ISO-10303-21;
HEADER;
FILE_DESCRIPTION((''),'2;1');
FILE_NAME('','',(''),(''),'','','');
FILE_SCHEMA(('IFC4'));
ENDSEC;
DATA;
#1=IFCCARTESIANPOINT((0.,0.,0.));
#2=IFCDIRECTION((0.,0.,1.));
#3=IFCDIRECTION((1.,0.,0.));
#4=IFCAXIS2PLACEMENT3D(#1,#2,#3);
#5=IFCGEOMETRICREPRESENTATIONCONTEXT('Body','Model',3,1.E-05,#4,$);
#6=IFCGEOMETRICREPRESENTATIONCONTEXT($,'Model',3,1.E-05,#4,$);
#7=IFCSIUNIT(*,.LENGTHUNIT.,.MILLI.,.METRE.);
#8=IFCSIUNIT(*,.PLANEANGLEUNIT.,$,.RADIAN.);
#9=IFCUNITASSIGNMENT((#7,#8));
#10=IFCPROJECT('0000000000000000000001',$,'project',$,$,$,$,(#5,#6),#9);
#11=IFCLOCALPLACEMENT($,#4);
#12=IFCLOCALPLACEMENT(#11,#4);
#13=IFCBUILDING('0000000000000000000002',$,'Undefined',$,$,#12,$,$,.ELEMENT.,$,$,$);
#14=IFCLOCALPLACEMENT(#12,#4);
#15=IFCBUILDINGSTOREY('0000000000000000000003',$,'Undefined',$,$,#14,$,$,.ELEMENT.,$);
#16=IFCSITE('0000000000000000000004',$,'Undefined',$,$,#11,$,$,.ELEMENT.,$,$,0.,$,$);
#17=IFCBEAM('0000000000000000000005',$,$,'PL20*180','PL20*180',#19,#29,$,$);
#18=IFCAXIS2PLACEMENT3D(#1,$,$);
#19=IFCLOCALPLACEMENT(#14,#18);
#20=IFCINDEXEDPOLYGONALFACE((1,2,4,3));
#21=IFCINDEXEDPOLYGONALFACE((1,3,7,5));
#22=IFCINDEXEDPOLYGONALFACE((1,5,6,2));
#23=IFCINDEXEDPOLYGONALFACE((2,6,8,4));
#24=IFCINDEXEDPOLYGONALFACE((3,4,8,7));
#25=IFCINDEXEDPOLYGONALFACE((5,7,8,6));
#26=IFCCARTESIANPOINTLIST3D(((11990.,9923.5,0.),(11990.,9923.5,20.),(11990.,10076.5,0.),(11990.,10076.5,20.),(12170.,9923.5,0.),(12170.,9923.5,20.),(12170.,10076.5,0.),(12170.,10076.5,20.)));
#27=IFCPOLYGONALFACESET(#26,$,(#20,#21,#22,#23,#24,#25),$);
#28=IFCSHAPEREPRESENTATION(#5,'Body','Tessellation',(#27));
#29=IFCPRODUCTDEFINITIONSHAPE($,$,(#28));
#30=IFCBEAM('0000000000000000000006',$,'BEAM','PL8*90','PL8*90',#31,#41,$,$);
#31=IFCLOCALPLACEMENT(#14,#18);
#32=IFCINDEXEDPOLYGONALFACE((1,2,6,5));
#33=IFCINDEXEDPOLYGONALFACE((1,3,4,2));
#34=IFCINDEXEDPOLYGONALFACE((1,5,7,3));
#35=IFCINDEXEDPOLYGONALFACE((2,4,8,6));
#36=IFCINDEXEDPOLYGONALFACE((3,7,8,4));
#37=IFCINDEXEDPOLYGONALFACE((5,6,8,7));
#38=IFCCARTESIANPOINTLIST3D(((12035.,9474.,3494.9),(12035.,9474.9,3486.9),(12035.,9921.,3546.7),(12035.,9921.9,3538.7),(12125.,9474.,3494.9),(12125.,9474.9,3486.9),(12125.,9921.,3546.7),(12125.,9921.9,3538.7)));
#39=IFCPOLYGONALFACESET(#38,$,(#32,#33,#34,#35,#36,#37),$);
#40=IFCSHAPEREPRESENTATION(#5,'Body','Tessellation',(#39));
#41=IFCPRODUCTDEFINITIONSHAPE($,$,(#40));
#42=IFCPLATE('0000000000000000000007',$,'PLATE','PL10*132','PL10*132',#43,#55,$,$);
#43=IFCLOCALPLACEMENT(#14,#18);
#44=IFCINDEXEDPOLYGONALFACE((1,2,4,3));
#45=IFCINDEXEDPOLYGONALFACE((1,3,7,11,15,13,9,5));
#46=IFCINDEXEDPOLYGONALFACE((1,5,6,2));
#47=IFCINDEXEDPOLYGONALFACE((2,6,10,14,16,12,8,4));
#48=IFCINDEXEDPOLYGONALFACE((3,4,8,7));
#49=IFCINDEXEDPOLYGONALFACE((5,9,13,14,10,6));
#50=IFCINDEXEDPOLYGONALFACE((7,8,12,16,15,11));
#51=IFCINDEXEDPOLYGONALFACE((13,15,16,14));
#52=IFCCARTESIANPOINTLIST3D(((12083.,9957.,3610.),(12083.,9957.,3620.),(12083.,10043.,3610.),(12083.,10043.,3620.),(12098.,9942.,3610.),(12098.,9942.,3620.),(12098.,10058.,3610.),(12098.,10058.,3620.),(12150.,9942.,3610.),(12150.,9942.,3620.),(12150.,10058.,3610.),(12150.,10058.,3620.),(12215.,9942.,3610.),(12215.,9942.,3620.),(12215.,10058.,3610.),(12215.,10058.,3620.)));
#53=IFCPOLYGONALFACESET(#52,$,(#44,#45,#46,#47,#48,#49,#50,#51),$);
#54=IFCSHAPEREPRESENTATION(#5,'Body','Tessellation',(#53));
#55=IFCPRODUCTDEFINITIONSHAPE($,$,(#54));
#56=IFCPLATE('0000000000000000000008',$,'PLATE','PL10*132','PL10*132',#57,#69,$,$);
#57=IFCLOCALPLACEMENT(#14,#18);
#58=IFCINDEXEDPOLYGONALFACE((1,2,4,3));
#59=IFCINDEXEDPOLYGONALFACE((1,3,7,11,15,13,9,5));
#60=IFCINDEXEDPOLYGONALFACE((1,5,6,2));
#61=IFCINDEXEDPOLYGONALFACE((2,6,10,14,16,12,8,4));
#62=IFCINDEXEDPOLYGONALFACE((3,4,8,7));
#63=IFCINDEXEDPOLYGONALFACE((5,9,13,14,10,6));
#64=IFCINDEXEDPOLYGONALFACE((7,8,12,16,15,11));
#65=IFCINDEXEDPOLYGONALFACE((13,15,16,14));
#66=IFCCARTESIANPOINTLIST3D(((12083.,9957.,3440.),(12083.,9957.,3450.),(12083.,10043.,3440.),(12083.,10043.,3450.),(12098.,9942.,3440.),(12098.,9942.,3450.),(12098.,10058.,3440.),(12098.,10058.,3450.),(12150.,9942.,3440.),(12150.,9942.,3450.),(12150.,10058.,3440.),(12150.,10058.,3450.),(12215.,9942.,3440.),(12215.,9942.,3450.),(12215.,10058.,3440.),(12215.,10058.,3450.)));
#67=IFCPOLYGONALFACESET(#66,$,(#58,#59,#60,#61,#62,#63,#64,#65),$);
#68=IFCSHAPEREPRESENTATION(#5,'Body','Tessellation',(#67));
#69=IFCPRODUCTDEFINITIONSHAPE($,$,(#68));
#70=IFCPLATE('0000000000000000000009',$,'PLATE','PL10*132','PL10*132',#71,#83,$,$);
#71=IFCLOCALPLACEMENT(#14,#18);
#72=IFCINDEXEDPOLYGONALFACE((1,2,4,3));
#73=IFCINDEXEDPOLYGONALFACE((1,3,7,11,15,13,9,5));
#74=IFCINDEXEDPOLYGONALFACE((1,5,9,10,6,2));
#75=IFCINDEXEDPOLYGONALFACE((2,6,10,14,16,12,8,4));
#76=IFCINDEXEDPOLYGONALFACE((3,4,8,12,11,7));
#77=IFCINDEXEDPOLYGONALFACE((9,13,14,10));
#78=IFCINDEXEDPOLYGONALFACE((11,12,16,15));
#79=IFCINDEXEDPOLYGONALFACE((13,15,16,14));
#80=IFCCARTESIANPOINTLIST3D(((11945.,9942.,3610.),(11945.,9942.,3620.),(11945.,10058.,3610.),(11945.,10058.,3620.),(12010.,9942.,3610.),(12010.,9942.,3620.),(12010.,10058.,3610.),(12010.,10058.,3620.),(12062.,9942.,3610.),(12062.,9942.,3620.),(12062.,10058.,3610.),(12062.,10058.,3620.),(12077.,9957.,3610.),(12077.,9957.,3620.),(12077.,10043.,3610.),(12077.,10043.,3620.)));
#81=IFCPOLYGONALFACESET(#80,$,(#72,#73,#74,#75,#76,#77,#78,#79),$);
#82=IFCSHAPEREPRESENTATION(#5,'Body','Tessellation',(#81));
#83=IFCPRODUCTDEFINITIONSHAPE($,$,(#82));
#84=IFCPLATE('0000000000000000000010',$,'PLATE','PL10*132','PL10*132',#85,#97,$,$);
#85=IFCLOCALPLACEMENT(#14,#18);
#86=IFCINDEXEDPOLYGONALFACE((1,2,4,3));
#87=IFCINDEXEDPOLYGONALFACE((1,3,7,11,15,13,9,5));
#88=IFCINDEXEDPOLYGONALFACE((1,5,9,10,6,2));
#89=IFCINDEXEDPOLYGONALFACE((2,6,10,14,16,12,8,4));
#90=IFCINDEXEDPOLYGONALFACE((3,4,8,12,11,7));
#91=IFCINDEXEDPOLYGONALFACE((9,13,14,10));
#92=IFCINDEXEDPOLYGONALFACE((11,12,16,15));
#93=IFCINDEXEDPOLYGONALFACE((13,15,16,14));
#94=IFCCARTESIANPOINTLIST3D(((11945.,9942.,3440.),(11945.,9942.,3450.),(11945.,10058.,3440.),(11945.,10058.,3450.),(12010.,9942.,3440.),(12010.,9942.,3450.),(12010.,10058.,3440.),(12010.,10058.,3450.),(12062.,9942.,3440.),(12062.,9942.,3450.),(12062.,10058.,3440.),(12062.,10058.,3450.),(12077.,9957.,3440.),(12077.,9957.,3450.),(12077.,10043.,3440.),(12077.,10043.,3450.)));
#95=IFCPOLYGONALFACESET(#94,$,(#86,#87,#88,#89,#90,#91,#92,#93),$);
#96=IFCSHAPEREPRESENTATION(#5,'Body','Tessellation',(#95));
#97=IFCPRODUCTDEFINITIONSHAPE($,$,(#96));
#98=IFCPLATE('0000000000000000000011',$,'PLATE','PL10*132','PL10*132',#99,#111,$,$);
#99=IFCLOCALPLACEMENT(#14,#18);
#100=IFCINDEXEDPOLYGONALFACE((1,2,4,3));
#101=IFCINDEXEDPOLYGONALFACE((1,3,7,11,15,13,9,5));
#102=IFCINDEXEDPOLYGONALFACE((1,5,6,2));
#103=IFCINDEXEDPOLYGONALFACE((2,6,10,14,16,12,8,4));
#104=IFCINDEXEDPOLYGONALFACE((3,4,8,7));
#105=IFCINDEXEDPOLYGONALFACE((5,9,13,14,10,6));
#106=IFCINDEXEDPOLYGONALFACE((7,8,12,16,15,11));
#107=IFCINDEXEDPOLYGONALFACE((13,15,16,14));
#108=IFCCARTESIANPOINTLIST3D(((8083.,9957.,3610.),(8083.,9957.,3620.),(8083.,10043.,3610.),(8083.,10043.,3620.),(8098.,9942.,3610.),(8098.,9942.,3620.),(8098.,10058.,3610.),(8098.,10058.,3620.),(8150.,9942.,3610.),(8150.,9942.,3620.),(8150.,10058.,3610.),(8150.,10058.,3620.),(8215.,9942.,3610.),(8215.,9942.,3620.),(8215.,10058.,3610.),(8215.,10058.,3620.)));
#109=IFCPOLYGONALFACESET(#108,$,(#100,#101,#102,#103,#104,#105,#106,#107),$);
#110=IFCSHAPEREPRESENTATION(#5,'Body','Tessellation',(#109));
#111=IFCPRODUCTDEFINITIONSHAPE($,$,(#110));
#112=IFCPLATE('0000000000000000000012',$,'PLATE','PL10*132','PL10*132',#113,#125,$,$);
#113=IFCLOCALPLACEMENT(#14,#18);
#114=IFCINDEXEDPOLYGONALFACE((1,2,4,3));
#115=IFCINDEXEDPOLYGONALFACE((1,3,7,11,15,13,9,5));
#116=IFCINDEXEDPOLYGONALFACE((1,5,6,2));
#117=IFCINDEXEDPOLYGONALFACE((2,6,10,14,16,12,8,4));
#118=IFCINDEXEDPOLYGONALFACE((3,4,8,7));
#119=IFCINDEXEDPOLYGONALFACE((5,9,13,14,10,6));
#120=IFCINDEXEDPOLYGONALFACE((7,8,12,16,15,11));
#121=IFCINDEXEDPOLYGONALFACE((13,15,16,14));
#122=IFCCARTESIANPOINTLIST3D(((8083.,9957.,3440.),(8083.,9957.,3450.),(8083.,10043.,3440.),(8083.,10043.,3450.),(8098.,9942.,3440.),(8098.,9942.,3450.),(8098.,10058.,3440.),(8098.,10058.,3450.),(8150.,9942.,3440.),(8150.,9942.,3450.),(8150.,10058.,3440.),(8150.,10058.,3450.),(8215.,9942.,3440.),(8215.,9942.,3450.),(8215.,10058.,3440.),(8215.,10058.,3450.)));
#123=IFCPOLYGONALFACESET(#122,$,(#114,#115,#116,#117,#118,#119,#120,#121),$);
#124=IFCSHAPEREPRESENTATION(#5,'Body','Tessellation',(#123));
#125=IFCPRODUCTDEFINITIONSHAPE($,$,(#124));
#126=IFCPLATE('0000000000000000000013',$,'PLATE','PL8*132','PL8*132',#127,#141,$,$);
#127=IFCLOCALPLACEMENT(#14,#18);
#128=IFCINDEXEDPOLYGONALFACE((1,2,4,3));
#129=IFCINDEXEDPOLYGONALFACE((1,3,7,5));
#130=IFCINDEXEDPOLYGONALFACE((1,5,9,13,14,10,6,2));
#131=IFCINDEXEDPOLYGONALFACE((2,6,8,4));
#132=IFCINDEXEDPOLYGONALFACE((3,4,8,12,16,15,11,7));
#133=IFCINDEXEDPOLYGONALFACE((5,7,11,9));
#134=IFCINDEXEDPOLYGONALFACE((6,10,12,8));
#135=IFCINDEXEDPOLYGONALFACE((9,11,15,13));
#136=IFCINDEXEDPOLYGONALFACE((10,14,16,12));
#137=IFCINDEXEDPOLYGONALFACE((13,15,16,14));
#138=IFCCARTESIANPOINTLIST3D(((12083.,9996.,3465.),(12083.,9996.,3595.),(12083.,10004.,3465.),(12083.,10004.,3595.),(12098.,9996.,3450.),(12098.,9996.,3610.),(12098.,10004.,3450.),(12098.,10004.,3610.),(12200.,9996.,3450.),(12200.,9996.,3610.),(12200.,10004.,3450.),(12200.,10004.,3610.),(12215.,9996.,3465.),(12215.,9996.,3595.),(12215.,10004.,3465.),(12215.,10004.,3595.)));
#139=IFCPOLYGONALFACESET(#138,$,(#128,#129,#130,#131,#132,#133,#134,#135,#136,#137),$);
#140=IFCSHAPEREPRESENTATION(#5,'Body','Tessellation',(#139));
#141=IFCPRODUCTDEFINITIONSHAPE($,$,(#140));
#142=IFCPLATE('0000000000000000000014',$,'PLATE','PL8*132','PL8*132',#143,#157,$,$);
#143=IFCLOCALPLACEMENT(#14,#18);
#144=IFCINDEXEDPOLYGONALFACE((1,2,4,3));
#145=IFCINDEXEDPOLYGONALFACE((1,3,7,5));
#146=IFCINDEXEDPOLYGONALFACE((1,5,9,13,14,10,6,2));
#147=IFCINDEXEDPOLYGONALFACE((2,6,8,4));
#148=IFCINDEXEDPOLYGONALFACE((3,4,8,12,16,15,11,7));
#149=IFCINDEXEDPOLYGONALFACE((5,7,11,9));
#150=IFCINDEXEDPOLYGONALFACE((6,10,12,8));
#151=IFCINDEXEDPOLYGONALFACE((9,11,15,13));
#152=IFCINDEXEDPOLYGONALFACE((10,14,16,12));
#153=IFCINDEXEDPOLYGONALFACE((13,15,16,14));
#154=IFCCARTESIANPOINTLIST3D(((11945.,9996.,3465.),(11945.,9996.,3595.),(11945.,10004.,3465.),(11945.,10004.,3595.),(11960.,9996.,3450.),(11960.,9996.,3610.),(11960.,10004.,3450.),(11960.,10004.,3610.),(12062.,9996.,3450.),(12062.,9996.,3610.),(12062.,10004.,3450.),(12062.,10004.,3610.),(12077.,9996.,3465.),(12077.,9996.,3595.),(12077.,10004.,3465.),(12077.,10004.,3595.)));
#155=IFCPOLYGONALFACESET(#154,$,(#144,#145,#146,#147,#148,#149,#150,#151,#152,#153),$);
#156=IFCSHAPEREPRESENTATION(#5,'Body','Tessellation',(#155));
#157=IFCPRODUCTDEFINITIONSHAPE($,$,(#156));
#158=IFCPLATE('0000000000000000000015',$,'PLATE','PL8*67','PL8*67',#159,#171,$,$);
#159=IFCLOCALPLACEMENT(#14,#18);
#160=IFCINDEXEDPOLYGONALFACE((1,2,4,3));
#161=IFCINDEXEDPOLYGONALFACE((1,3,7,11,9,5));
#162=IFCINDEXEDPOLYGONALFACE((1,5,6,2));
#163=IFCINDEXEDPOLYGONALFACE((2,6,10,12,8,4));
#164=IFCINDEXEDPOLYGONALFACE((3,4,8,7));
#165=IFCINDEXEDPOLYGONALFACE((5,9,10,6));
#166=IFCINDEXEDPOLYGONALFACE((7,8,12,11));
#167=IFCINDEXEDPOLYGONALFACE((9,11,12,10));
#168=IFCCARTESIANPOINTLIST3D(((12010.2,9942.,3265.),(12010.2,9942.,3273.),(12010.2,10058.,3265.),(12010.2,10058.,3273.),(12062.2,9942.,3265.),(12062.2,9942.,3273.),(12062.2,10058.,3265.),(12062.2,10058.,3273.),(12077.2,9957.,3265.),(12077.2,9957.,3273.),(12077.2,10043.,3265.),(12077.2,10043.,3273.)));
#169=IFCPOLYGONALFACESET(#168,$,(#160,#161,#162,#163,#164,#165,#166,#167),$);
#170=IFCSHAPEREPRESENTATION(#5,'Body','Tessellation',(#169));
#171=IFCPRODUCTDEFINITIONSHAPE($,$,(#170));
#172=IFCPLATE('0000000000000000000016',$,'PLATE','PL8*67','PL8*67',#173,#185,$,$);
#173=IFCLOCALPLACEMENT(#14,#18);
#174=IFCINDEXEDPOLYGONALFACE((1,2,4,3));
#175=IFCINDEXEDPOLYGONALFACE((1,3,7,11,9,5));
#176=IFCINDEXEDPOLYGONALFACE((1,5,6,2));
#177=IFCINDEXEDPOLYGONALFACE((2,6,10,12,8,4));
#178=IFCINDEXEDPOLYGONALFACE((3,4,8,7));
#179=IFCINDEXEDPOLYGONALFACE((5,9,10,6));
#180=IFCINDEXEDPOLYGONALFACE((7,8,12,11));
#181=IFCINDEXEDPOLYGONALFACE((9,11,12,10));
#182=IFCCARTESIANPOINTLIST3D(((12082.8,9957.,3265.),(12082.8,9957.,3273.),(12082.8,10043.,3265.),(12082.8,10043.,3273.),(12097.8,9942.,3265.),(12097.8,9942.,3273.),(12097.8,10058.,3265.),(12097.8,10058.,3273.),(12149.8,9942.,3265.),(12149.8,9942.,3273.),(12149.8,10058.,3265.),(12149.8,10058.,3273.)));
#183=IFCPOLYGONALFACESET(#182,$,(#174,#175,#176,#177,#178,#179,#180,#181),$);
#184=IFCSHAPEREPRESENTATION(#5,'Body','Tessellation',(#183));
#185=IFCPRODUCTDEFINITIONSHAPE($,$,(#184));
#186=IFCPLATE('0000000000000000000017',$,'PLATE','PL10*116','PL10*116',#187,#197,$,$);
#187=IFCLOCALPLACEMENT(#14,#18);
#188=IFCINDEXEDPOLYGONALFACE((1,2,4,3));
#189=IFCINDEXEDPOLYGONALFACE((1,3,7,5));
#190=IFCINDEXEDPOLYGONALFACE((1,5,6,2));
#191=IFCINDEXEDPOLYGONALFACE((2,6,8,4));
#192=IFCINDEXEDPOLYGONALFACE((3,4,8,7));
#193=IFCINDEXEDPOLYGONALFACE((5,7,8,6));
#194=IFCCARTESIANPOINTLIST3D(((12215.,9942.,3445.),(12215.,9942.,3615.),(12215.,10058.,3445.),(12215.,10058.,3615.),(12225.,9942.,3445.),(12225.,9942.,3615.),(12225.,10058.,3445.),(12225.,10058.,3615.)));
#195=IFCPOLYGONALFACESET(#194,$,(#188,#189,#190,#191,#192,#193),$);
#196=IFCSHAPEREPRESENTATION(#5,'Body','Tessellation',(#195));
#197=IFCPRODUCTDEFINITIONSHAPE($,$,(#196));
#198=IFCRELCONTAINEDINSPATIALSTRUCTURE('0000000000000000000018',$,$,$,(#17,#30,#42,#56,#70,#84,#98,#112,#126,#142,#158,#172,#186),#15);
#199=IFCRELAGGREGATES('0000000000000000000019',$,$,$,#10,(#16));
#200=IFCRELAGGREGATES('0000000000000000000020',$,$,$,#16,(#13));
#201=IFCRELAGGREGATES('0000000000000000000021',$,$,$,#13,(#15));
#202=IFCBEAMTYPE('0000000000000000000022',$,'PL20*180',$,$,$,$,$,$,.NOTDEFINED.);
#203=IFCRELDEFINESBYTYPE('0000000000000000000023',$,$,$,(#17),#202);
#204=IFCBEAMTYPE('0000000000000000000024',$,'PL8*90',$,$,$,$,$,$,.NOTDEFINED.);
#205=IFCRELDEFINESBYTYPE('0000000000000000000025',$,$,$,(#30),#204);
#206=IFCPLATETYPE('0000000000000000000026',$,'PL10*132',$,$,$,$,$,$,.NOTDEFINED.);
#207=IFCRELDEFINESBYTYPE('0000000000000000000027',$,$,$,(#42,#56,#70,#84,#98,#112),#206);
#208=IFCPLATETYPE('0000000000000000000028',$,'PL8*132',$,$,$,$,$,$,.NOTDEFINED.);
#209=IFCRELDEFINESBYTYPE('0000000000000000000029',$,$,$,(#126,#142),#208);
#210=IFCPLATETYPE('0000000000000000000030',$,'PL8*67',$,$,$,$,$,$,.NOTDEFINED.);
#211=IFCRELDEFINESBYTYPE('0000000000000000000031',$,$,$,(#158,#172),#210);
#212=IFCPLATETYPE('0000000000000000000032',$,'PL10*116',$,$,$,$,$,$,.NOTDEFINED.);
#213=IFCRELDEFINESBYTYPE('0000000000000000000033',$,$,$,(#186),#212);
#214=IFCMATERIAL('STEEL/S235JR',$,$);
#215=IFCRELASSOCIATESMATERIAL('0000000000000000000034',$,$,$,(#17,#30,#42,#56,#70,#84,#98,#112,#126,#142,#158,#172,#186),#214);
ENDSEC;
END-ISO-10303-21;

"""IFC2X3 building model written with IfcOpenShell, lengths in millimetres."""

from ifc_helpers import new_model, si_unit, frame, origin_with_axes, origin_2d_with_axis, place, context, project, spatial, polyline, rectangle, outline, extrude, material, type_object, element, save


model = new_model("IFC2X3")

# Units and contexts
model_context_1 = context("Model", 3, precision=1e-05, world=origin_with_axes(), identifier="Body")
model_context_2 = context("Model", 3, precision=1e-05, world=origin_with_axes())
ifc_project = project(units=[si_unit("LENGTHUNIT", "METRE", prefix="MILLI"), si_unit("PLANEANGLEUNIT", "RADIAN")], contexts=[model_context_1, model_context_2])

# Site, building, storey
site_placement = place(None, origin_with_axes())
site = spatial("IfcSite", under=ifc_project, at=site_placement, Name="Undefined", CompositionType="ELEMENT", RefElevation=0.0)
building_placement = place(site_placement, origin_with_axes())
building = spatial("IfcBuilding", under=site, at=building_placement, Name="Undefined", CompositionType="ELEMENT")
storey_placement = place(building_placement, origin_with_axes())
storey = spatial("IfcBuildingStorey", under=building, at=storey_placement, Name="Undefined", CompositionType="ELEMENT")

# Shared definitions
ifc_material = material(Name="STEEL/S235JR")

# Beams
beam_type_1 = type_object("IfcBeamType", Name="PL20*180", PredefinedType="NOTDEFINED")
beam_1_placement = place(storey_placement, frame((12080.0, 9923.5, 10.0), z_axis=(-1.0, 0.0, 0.0), x_axis=(0.0, 1.0, 0.0)))
element("IfcBeam", 1, at=beam_1_placement, inside=storey, type_object=beam_type_1, material=ifc_material, Description="PL20*180", ObjectType="PL20*180", context=model_context_1, shape_type="SweptSolid", body=[
    extrude(rectangle(XDim=20.0, YDim=180.0, at=origin_2d_with_axis()), frame((153.0, 0.0, 0.0), z_axis=(-1.0, 0.0, 0.0), x_axis=(0.0, -1.0, 0.0)), (0.0, 0.0, 1.0), 153.0),
])
beam_type_2 = type_object("IfcBeamType", Name="PL8*90", PredefinedType="NOTDEFINED")
beam_2_placement = place(storey_placement, frame((12080.0, 9921.4, 3542.7), z_axis=(1.0, 0.0, 0.0), x_axis=(0.0, -0.993355, -0.115087)))
element("IfcBeam", 2, at=beam_2_placement, inside=storey, type_object=beam_type_2, material=ifc_material, Name="BEAM", Description="PL8*90", ObjectType="PL8*90", context=model_context_1, shape_type="SweptSolid", body=[
    extrude(rectangle(XDim=8.0, YDim=90.0, at=origin_2d_with_axis()), frame((450.0, 0.0, 0.0), z_axis=(-1.0, 0.0, 0.0), x_axis=(0.0, -1.0, 0.0)), (0.0, 0.0, 1.0), 450.0),
])

# Plates
plate_type_1 = type_object("IfcPlateType", Name="PL10*132", PredefinedType="NOTDEFINED")
for number, where, z_axis, x_axis, name in (
    (3, (12083.0, 10058.0, 3615.0), (0.0, 0.0, -1.0), (1.0, 0.0, 0.0), "PLATE"),
    (4, (12083.0, 10058.0, 3445.0), (0.0, 0.0, -1.0), (1.0, 0.0, 0.0), "PLATE"),
    (5, (12077.0, 10058.0, 3615.0), (0.0, 0.0, 1.0), (-1.0, 0.0, 0.0), "PLATE"),
    (6, (12077.0, 10058.0, 3445.0), (0.0, 0.0, 1.0), (-1.0, 0.0, 0.0), "PLATE"),
    (7, (8083.0, 10058.0, 3615.0), (0.0, 0.0, -1.0), (1.0, 0.0, 0.0), "PLATE"),
    (8, (8083.0, 10058.0, 3445.0), (0.0, 0.0, -1.0), (1.0, 0.0, 0.0), "PLATE"),
):
    element("IfcPlate", number, at=place(storey_placement, frame(where, z_axis=z_axis, x_axis=x_axis)), inside=storey, type_object=plate_type_1, material=ifc_material, Name=name, Description="PL10*132", ObjectType="PL10*132", context=model_context_1, shape_type="SweptSolid", body=[
        extrude(outline(polyline([(0.0, 15.0), (15.0, 0.0), (67.0, 0.0), (132.0, 0.0), (132.0, 116.0), (67.0, 116.0), (15.0, 116.0), (0.0, 101.0), (0.0, 15.0)])), frame((0.0, 0.0, -5.0), z_axis=(0.0, 0.0, 1.0), x_axis=(1.0, 0.0, 0.0)), (0.0, 0.0, 1.0), 10.0),
    ])
plate_type_2 = type_object("IfcPlateType", Name="PL8*132", PredefinedType="NOTDEFINED")
for number, where, z_axis, x_axis, name in (
    (9, (12083.0, 10000.0, 3610.0), (0.0, 1.0, 0.0), (1.0, 0.0, 0.0), "PLATE"),
    (10, (12077.0, 10000.0, 3610.0), (0.0, -1.0, 0.0), (-1.0, 0.0, 0.0), "PLATE"),
):
    element("IfcPlate", number, at=place(storey_placement, frame(where, z_axis=z_axis, x_axis=x_axis)), inside=storey, type_object=plate_type_2, material=ifc_material, Name=name, Description="PL8*132", ObjectType="PL8*132", context=model_context_1, shape_type="SweptSolid", body=[
        extrude(outline(polyline([(0.0, 15.0), (15.0, 0.0), (117.0, 0.0), (132.0, 15.0), (132.0, 145.0), (117.0, 160.0), (15.0, 160.0), (0.0, 145.0), (0.0, 15.0)])), frame((0.0, 0.0, -4.0), z_axis=(0.0, 0.0, 1.0), x_axis=(1.0, 0.0, 0.0)), (0.0, 0.0, 1.0), 8.0),
    ])
plate_type_3 = type_object("IfcPlateType", Name="PL8*67", PredefinedType="NOTDEFINED")
plate_1_placement = place(storey_placement, frame((12010.2, 9942.0, 3269.0), z_axis=(0.0, 0.0, 1.0), x_axis=(1.0, 0.0, 0.0)))
element("IfcPlate", 11, at=plate_1_placement, inside=storey, type_object=plate_type_3, material=ifc_material, Name="PLATE", Description="PL8*67", ObjectType="PL8*67", context=model_context_1, shape_type="SweptSolid", body=[
    extrude(outline(polyline([(0.0, 0.0), (52.0, 0.0), (67.0, 15.0), (67.0, 101.0), (52.0, 116.0), (0.0, 116.0), (0.0, 0.0)])), frame((0.0, 0.0, -4.0), z_axis=(0.0, 0.0, 1.0), x_axis=(1.0, 0.0, 0.0)), (0.0, 0.0, 1.0), 8.0),
])
plate_2_placement = place(storey_placement, frame((12082.8, 9942.0, 3269.0), z_axis=(0.0, 0.0, 1.0), x_axis=(1.0, 0.0, 0.0)))
element("IfcPlate", 12, at=plate_2_placement, inside=storey, type_object=plate_type_3, material=ifc_material, Name="PLATE", Description="PL8*67", ObjectType="PL8*67", context=model_context_1, shape_type="SweptSolid", body=[
    extrude(outline(polyline([(0.0, 15.0), (15.0, 0.0), (67.0, 0.0), (67.0, 116.0), (15.0, 116.0), (0.0, 101.0), (0.0, 15.0)])), frame((0.0, 0.0, -4.0), z_axis=(0.0, 0.0, 1.0), x_axis=(1.0, 0.0, 0.0)), (0.0, 0.0, 1.0), 8.0),
])
plate_type_4 = type_object("IfcPlateType", Name="PL10*116", PredefinedType="NOTDEFINED")
for number, where, z_axis, x_axis, name in (
    (13, (12220.0, 10058.0, 3615.0), (1.0, 0.0, 0.0), (0.0, -1.0, 0.0), "PLATE"),
):
    element("IfcPlate", number, at=place(storey_placement, frame(where, z_axis=z_axis, x_axis=x_axis)), inside=storey, type_object=plate_type_4, material=ifc_material, Name=name, Description="PL10*116", ObjectType="PL10*116", context=model_context_1, shape_type="SweptSolid", body=[
        extrude(outline(polyline([(0.0, 0.0), (116.0, 0.0), (116.0, 170.0), (0.0, 170.0), (0.0, 0.0)])), frame((0.0, 0.0, -5.0), z_axis=(0.0, 0.0, 1.0), x_axis=(1.0, 0.0, 0.0)), (0.0, 0.0, 1.0), 10.0),
    ])

save(model, "model.ifc")
